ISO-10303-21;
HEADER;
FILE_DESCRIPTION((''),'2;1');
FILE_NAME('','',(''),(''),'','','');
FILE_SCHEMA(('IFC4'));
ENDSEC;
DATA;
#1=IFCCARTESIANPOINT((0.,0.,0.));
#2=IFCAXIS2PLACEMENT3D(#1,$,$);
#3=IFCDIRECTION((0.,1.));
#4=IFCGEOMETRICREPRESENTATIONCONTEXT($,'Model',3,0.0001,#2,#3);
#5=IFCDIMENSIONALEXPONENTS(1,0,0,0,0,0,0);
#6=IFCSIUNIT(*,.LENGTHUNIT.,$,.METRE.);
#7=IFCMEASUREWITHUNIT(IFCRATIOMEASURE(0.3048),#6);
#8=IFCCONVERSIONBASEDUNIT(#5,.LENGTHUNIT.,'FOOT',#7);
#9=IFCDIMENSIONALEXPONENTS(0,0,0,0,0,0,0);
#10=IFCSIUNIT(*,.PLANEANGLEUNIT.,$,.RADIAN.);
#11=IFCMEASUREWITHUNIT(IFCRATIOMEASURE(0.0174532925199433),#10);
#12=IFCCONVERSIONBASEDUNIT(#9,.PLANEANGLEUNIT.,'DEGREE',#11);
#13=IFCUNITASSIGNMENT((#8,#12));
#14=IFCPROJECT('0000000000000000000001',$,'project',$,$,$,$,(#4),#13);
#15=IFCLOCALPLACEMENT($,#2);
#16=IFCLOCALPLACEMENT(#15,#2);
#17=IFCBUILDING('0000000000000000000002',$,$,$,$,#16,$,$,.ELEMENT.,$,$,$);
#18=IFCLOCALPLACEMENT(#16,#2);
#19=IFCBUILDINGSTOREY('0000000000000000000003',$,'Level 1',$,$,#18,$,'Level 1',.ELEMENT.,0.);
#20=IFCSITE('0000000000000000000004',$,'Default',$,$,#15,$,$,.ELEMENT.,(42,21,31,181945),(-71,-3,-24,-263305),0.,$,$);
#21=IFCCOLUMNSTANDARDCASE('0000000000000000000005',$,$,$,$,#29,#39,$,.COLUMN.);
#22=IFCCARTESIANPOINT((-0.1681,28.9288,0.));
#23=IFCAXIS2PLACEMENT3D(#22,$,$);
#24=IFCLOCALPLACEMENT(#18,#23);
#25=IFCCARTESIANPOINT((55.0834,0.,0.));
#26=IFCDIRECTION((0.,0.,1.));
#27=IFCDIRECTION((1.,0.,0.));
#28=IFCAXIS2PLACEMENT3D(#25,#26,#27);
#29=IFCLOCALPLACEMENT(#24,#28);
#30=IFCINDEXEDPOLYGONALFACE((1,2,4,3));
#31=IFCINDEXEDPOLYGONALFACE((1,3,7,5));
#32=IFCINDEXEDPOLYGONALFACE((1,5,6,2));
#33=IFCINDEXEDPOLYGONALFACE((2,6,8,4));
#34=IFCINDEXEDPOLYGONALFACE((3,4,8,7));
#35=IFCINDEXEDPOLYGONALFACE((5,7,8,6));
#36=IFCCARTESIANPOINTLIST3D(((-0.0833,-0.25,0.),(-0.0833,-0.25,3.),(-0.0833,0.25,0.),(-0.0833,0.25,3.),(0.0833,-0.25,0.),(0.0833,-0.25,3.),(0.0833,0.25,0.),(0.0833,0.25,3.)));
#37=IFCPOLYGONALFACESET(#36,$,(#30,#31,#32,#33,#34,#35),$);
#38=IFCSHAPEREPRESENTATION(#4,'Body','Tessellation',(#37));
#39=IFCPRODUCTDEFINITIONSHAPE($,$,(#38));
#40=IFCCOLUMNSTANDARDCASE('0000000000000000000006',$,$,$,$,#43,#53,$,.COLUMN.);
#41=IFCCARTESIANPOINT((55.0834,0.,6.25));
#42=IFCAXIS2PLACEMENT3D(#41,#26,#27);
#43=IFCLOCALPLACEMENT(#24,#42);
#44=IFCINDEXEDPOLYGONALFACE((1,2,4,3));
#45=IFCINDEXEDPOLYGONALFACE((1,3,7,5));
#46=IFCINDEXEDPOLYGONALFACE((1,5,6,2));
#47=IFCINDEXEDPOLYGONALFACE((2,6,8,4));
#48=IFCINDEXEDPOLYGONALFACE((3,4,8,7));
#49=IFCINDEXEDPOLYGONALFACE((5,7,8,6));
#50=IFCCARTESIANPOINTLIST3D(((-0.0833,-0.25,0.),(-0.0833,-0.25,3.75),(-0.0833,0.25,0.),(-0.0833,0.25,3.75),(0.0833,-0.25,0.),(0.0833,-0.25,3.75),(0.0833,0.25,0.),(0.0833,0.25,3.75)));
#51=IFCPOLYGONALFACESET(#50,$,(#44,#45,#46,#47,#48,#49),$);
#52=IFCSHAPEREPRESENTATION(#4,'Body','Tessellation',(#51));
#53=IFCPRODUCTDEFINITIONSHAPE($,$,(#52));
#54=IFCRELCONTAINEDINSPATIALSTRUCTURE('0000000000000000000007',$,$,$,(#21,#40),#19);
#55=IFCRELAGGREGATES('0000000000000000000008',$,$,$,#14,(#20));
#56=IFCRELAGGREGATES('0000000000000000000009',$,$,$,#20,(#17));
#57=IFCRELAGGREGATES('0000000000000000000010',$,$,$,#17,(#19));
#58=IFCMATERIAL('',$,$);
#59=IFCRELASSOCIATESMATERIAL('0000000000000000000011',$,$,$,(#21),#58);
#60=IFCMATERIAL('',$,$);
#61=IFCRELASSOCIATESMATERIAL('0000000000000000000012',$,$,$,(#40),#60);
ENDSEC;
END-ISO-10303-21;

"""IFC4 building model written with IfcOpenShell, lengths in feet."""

from ifc_helpers import new_model, entity, si_unit, converted_unit, direction, frame, origin, place, context, project, spatial, rectangle, extrude, material, element, save


model = new_model("IFC4")

# Units and contexts
model_context = context("Model", 3, precision=0.0001, world=origin(), true_north=direction((0.0, 1.0)))
ifc_project = project(units=[converted_unit("LENGTHUNIT", "FOOT", entity("IfcRatioMeasure", 0.3048), si_unit("LENGTHUNIT", "METRE"), dimensions=[1, 0, 0, 0, 0, 0, 0]), converted_unit("PLANEANGLEUNIT", "DEGREE", entity("IfcRatioMeasure", 0.0174532925199433), si_unit("PLANEANGLEUNIT", "RADIAN"), dimensions=[0, 0, 0, 0, 0, 0, 0])], contexts=[model_context])

# Site, building, storey
site_placement = place(None, origin())
site = spatial("IfcSite", under=ifc_project, at=site_placement, Name="Default", CompositionType="ELEMENT", RefLatitude=(42, 21, 31, 181945), RefLongitude=(-71, -3, -24, -263305), RefElevation=0.0)
building_placement = place(site_placement, origin())
building = spatial("IfcBuilding", under=site, at=building_placement, CompositionType="ELEMENT")
storey_placement = place(building_placement, origin())
storey = spatial("IfcBuildingStorey", under=building, at=storey_placement, Name="Level 1", LongName="Level 1", CompositionType="ELEMENT", Elevation=0.0)

# Columns
ifc_material_1 = material(Name="")
placement = place(storey_placement, frame((-0.1681, 28.9288, 0.0)))
for number, where, z_axis, x_axis in (
    (1, (55.0834, 0.0, 0.0), (0.0, 0.0, 1.0), (1.0, 0.0, 0.0)),
):
    element("IfcColumnStandardCase", number, at=place(placement, frame(where, z_axis=z_axis, x_axis=x_axis)), inside=storey, material=ifc_material_1, PredefinedType="COLUMN", context=model_context, shape_type="SweptSolid", body=[
        extrude(rectangle(XDim=0.1667, YDim=0.5), origin(), (0.0, 0.0, 1.0), 3.0),
    ])
ifc_material_2 = material(Name="")
for number, where, z_axis, x_axis in (
    (2, (55.0834, 0.0, 6.25), (0.0, 0.0, 1.0), (1.0, 0.0, 0.0)),
):
    element("IfcColumnStandardCase", number, at=place(placement, frame(where, z_axis=z_axis, x_axis=x_axis)), inside=storey, material=ifc_material_2, PredefinedType="COLUMN", context=model_context, shape_type="SweptSolid", body=[
        extrude(rectangle(XDim=0.1667, YDim=0.5), origin(), (0.0, 0.0, 1.0), 3.75),
    ])

save(model, "model.ifc")
